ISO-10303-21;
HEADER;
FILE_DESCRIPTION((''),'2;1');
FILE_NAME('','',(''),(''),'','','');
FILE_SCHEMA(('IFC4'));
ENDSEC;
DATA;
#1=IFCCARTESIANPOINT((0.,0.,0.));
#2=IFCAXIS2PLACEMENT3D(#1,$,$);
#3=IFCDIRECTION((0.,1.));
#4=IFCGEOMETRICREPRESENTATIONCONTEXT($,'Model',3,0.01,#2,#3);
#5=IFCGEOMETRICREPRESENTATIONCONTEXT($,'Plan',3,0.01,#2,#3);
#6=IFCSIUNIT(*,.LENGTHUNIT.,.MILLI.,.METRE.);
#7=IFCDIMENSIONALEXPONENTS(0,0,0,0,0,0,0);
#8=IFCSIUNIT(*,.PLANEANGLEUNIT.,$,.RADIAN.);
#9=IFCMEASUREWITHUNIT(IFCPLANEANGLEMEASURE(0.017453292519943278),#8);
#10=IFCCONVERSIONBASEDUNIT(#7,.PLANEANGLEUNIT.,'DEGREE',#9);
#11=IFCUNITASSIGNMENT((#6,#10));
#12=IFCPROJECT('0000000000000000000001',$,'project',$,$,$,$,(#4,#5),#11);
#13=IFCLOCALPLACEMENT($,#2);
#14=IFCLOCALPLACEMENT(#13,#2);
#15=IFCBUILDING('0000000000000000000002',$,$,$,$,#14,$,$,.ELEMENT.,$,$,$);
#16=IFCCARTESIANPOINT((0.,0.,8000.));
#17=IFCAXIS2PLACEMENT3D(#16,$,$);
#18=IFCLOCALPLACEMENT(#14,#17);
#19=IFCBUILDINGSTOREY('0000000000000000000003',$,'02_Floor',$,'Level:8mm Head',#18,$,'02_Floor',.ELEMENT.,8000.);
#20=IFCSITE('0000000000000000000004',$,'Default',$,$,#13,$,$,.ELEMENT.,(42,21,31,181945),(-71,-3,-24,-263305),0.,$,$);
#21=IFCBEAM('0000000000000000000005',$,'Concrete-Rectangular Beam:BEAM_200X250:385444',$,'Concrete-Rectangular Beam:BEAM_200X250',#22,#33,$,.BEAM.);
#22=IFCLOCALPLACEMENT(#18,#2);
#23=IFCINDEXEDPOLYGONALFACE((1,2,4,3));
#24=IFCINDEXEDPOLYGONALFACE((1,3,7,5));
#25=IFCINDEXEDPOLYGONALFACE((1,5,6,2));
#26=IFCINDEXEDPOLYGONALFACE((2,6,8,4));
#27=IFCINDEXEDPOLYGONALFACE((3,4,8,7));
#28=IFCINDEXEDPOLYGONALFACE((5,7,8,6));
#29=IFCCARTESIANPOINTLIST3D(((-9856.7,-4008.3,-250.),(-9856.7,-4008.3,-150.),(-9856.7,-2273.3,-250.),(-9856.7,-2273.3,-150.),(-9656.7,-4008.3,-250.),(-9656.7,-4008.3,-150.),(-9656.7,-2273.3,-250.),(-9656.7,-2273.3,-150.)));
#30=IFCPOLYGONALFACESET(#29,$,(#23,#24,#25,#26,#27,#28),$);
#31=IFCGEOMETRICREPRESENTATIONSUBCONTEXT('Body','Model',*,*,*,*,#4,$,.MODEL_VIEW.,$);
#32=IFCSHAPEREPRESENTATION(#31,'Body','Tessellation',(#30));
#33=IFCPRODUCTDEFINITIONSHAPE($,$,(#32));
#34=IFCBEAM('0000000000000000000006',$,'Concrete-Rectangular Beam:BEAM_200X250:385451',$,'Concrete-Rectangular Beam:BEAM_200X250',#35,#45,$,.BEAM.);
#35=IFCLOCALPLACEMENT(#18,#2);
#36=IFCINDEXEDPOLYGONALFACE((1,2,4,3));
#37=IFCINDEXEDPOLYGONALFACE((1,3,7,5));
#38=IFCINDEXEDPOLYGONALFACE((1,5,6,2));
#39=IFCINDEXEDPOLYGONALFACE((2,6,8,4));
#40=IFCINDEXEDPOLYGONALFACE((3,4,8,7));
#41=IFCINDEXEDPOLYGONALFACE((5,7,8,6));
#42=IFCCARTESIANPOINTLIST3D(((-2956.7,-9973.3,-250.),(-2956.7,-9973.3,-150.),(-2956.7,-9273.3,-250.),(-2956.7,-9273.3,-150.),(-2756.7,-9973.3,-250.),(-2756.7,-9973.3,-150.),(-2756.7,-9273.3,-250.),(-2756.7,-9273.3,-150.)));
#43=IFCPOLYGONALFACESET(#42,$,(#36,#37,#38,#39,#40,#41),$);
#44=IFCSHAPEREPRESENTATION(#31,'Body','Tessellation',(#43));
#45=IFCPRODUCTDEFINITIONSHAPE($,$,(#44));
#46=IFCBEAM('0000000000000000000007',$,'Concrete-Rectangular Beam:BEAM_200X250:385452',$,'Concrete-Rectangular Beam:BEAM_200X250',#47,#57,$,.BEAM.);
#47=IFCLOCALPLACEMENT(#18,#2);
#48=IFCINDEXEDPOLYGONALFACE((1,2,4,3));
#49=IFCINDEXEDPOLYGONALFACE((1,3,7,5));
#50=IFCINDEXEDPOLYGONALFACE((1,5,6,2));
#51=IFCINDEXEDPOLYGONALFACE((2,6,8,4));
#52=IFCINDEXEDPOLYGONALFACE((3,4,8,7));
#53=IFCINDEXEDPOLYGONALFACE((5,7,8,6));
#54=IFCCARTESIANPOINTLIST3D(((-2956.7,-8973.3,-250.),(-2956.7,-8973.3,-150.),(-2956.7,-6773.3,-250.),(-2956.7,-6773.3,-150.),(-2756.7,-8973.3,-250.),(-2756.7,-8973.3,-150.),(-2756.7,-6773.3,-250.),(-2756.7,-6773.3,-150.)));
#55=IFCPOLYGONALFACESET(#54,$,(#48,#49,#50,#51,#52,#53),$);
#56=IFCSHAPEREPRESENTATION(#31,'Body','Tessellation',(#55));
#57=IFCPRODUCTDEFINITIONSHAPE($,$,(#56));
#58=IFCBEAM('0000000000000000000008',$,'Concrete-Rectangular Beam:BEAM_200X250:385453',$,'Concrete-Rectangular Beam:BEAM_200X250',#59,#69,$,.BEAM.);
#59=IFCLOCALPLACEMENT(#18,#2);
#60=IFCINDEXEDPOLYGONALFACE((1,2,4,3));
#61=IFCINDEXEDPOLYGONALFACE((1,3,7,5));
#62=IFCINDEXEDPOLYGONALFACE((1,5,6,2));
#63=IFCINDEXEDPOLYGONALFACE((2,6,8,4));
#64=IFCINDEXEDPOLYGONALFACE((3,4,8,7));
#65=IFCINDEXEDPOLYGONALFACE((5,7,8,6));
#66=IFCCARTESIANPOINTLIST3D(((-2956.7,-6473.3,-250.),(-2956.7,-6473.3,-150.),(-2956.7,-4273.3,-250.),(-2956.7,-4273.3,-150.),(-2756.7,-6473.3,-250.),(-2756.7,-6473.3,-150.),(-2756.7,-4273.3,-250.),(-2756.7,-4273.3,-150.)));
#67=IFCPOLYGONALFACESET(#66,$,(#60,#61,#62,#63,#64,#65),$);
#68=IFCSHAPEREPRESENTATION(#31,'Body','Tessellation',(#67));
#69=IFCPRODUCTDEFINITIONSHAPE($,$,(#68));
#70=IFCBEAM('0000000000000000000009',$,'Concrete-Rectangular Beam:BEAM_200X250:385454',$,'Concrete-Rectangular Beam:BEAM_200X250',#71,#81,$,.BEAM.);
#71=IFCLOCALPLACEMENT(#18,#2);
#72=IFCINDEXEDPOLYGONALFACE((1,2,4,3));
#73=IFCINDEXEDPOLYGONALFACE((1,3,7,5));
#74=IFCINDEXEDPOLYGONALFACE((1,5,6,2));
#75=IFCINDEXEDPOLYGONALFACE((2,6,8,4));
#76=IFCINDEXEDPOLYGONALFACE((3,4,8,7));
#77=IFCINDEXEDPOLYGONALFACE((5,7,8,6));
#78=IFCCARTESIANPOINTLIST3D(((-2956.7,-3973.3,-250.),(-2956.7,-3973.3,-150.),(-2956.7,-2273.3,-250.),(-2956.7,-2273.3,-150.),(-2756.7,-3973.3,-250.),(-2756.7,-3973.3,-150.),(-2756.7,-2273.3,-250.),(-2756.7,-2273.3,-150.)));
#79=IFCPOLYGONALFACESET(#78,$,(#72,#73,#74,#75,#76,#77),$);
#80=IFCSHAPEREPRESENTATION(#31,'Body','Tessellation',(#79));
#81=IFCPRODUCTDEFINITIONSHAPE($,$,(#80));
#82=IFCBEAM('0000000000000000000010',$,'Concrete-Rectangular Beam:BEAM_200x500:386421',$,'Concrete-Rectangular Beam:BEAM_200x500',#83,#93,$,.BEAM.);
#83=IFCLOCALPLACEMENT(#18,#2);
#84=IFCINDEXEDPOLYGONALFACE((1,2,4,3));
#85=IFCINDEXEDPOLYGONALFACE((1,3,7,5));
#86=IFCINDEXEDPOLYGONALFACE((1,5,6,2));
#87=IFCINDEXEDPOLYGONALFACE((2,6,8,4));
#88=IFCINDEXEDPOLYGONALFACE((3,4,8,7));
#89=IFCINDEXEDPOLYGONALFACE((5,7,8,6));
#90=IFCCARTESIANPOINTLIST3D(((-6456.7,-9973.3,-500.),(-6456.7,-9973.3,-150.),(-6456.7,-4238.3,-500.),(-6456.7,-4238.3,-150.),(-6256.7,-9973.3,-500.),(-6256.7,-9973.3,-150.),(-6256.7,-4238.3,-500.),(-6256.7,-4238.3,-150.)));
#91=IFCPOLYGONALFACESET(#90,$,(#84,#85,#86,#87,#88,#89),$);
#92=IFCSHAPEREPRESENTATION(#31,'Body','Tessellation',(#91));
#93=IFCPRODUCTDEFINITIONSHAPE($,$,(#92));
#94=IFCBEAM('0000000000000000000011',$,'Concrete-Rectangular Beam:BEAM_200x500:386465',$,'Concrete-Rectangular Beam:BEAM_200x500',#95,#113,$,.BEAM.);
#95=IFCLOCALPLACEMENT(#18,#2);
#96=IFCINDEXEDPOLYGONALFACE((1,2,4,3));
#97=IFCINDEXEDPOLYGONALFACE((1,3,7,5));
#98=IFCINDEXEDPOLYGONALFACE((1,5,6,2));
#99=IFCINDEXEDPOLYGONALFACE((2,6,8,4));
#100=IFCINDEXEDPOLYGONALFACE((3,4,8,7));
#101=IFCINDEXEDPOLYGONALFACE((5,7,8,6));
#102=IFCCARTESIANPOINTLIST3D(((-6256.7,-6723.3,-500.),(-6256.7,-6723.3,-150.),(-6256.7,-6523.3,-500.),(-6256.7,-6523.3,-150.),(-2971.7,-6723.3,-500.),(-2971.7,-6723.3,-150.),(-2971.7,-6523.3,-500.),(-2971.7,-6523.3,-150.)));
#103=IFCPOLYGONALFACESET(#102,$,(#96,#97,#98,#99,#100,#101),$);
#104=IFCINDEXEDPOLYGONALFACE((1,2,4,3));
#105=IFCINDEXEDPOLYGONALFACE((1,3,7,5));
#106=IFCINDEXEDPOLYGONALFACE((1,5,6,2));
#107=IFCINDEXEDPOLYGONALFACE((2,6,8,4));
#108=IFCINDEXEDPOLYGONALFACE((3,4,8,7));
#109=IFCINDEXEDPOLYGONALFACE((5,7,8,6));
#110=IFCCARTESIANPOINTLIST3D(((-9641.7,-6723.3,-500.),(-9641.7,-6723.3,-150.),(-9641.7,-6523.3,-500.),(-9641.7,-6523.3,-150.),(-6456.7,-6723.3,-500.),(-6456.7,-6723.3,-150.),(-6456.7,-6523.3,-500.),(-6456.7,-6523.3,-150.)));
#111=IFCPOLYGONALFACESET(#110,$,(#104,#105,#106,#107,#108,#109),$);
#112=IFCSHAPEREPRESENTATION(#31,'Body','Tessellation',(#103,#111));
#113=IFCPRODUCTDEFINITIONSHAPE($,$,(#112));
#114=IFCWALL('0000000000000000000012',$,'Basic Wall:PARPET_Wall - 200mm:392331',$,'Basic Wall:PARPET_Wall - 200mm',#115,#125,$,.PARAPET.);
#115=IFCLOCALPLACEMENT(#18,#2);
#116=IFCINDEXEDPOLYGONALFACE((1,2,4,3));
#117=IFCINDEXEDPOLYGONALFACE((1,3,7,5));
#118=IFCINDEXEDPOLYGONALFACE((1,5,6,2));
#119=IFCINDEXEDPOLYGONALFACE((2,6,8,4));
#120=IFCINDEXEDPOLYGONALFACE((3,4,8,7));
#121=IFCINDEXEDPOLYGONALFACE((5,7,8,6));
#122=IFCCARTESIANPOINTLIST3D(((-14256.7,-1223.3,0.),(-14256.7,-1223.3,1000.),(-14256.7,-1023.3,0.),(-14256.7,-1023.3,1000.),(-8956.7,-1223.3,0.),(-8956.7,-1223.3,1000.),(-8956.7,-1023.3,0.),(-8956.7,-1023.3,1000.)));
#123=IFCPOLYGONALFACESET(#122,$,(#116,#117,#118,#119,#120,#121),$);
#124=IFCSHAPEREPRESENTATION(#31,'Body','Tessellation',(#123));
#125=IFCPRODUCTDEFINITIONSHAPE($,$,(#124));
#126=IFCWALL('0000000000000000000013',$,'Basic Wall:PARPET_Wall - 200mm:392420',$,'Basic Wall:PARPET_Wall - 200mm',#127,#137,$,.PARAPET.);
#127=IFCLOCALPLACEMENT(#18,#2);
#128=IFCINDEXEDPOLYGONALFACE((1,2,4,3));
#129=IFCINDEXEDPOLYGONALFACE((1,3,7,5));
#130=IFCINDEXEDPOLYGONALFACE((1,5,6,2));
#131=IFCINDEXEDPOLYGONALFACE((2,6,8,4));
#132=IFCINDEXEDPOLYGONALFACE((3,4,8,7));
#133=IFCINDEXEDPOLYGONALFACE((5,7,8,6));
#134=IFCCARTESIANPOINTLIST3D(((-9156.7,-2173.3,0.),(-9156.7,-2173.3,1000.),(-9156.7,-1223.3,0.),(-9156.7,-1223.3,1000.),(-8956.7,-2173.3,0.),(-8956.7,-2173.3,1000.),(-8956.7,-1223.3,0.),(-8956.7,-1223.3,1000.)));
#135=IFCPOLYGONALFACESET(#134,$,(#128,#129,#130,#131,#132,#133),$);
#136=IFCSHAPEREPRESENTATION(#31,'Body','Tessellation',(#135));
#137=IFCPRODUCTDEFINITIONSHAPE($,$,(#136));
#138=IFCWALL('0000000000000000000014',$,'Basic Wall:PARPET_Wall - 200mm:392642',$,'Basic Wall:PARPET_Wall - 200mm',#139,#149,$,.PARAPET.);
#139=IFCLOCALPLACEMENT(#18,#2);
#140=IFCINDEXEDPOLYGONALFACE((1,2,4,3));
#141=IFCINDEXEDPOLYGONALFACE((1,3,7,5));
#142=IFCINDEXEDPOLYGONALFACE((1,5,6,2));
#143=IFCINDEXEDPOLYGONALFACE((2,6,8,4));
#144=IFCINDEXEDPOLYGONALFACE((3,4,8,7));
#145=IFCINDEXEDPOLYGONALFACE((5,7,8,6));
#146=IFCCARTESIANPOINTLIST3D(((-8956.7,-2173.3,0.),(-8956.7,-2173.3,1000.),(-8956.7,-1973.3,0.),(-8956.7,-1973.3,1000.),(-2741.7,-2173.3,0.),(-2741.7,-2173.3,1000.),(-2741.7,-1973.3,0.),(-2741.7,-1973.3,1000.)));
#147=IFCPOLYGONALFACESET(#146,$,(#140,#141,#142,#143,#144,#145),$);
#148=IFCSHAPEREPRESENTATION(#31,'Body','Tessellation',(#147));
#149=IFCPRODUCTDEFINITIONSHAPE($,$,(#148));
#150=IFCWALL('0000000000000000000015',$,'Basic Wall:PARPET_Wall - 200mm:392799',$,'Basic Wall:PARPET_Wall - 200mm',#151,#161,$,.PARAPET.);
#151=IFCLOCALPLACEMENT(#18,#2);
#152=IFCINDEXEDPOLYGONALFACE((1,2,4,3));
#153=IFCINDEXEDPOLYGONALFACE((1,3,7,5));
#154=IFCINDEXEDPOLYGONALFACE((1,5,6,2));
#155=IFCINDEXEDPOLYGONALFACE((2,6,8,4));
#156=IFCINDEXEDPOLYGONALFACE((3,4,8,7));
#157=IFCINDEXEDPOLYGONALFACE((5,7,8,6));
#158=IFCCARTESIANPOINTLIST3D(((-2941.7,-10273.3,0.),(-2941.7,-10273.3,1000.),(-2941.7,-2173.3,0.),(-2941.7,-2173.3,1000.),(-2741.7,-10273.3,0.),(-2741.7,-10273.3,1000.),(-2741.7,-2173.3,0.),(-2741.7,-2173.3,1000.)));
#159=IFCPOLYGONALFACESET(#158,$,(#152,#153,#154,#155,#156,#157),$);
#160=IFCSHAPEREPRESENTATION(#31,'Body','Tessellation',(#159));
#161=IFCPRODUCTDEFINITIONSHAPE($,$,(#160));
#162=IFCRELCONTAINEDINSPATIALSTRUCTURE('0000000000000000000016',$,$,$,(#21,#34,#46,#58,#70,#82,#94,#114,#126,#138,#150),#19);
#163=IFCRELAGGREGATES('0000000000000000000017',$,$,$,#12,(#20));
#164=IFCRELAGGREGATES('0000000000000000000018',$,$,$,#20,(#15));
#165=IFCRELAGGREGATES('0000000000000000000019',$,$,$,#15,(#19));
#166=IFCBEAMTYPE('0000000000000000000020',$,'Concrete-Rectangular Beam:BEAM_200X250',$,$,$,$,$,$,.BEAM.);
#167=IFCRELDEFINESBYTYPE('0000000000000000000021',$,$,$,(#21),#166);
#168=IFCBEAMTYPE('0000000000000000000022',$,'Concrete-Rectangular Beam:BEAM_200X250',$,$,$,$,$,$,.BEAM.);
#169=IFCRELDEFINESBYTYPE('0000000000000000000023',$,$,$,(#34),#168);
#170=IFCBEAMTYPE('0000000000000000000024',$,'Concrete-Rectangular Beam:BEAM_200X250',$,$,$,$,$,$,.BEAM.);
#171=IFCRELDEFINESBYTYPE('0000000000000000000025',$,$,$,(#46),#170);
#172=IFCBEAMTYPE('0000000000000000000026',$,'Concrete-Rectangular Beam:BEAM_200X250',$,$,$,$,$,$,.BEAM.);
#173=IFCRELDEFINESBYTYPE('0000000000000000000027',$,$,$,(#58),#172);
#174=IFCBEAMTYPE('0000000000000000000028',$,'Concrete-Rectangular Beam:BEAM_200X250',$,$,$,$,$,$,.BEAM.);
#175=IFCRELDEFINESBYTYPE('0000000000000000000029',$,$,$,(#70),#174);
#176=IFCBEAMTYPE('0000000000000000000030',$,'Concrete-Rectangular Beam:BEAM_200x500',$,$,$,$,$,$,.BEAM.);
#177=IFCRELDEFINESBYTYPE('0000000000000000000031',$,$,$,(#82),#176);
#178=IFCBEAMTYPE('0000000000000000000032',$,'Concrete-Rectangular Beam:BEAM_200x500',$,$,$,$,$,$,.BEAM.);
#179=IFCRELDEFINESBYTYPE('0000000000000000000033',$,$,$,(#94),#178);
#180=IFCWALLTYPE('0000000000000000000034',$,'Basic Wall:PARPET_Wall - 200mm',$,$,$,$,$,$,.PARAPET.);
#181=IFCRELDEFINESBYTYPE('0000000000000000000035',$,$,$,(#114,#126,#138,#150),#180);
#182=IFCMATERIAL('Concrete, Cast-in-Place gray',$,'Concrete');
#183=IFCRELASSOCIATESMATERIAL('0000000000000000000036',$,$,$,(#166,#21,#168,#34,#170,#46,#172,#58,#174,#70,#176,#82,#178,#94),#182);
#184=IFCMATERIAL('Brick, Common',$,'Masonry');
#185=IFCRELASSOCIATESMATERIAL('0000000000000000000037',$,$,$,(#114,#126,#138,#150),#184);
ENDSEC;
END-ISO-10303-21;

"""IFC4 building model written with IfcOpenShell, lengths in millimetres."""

from ifc_helpers import new_model, entity, si_unit, converted_unit, direction, frame, origin, place, context, subcontext, project, spatial, indexed_curve, outline, extrude, source, transform, mapped, material, type_object, type_shapes, element, save


model = new_model("IFC4")

# Units and contexts
model_context = context("Model", 3, precision=0.01, world=origin(), true_north=direction((0.0, 1.0)))
plan_context = context("Plan", 3, precision=0.01, world=origin(), true_north=direction((0.0, 1.0)))
body_context = subcontext(model_context, "Body", "Model", "MODEL_VIEW")
ifc_project = project(units=[si_unit("LENGTHUNIT", "METRE", prefix="MILLI"), converted_unit("PLANEANGLEUNIT", "DEGREE", entity("IfcPlaneAngleMeasure", 0.017453292519943278), si_unit("PLANEANGLEUNIT", "RADIAN"), dimensions=[0, 0, 0, 0, 0, 0, 0])], contexts=[model_context, plan_context])

# Site, building, storey
site_placement = place(None, origin())
site = spatial("IfcSite", under=ifc_project, at=site_placement, Name="Default", CompositionType="ELEMENT", RefLatitude=(42, 21, 31, 181945), RefLongitude=(-71, -3, -24, -263305), RefElevation=0.0)
building_placement = place(site_placement, origin())
building = spatial("IfcBuilding", under=site, at=building_placement, CompositionType="ELEMENT")
storey_placement = place(building_placement, frame((0.0, 0.0, 8000.0)))
storey = spatial("IfcBuildingStorey", under=building, at=storey_placement, Name="02_Floor", ObjectType="Level:8mm Head", LongName="02_Floor", CompositionType="ELEMENT", Elevation=8000.0)

# Beams
ifc_material_1 = material(Name="Concrete, Cast-in-Place gray", Category="Concrete")
beam_type_1 = type_object("IfcBeamType", Name="Concrete-Rectangular Beam:BEAM_200X250", PredefinedType="BEAM", material=ifc_material_1)
shared_shape_1 = source(origin(), body_context, "Body", "SweptSolid", [
    extrude(outline(indexed_curve([(-100.0, -50.0), (100.0, -50.0), (100.0, 50.0), (-100.0, 50.0), (-100.0, -50.0)], self_intersect=False)), frame((-9756.7, -4008.3, 7800.0), z_axis=(0.0, 1.0, 0.0), x_axis=(-1.0, 0.0, 0.0)), (0.0, 0.0, 1.0), 1735.0),
])
type_shapes(beam_type_1, [shared_shape_1])
beam_1_placement = place(storey_placement, frame((0.0, 0.0, -8000.0)))
element("IfcBeam", 1, at=beam_1_placement, inside=storey, type_object=beam_type_1, material=ifc_material_1, Name="Concrete-Rectangular Beam:BEAM_200X250:385444", ObjectType="Concrete-Rectangular Beam:BEAM_200X250", PredefinedType="BEAM", context=body_context, shape_type="MappedRepresentation", body=[
    mapped(shared_shape_1, transform((0.0, 0.0, 0.0), scale=1.0)),
])
beam_type_2 = type_object("IfcBeamType", Name="Concrete-Rectangular Beam:BEAM_200X250", PredefinedType="BEAM", material=ifc_material_1)
shared_shape_2 = source(origin(), body_context, "Body", "SweptSolid", [
    extrude(outline(indexed_curve([(-100.0, -50.0), (100.0, -50.0), (100.0, 50.0), (-100.0, 50.0), (-100.0, -50.0)], self_intersect=False)), frame((-2856.7, -9973.3, 7800.0), z_axis=(0.0, 1.0, 0.0), x_axis=(-1.0, 0.0, 0.0)), (0.0, 0.0, 1.0), 700.0),
])
type_shapes(beam_type_2, [shared_shape_2])
beam_2_placement = place(storey_placement, frame((0.0, 0.0, -8000.0)))
element("IfcBeam", 2, at=beam_2_placement, inside=storey, type_object=beam_type_2, material=ifc_material_1, Name="Concrete-Rectangular Beam:BEAM_200X250:385451", ObjectType="Concrete-Rectangular Beam:BEAM_200X250", PredefinedType="BEAM", context=body_context, shape_type="MappedRepresentation", body=[
    mapped(shared_shape_2, transform((0.0, 0.0, 0.0), scale=1.0)),
])
beam_type_3 = type_object("IfcBeamType", Name="Concrete-Rectangular Beam:BEAM_200X250", PredefinedType="BEAM", material=ifc_material_1)
shared_shape_3 = source(origin(), body_context, "Body", "SweptSolid", [
    extrude(outline(indexed_curve([(-100.0, -50.0), (100.0, -50.0), (100.0, 50.0), (-100.0, 50.0), (-100.0, -50.0)], self_intersect=False)), frame((-2856.7, -8973.3, 7800.0), z_axis=(0.0, 1.0, 0.0), x_axis=(-1.0, 0.0, 0.0)), (0.0, 0.0, 1.0), 2200.0),
])
type_shapes(beam_type_3, [shared_shape_3])
beam_3_placement = place(storey_placement, frame((0.0, 0.0, -8000.0)))
element("IfcBeam", 3, at=beam_3_placement, inside=storey, type_object=beam_type_3, material=ifc_material_1, Name="Concrete-Rectangular Beam:BEAM_200X250:385452", ObjectType="Concrete-Rectangular Beam:BEAM_200X250", PredefinedType="BEAM", context=body_context, shape_type="MappedRepresentation", body=[
    mapped(shared_shape_3, transform((0.0, 0.0, 0.0), scale=1.0)),
])
beam_type_4 = type_object("IfcBeamType", Name="Concrete-Rectangular Beam:BEAM_200X250", PredefinedType="BEAM", material=ifc_material_1)
shared_shape_4 = source(origin(), body_context, "Body", "SweptSolid", [
    extrude(outline(indexed_curve([(-100.0, -50.0), (100.0, -50.0), (100.0, 50.0), (-100.0, 50.0), (-100.0, -50.0)], self_intersect=False)), frame((-2856.7, -6473.3, 7800.0), z_axis=(0.0, 1.0, 0.0), x_axis=(-1.0, 0.0, 0.0)), (0.0, 0.0, 1.0), 2200.0),
])
type_shapes(beam_type_4, [shared_shape_4])
beam_4_placement = place(storey_placement, frame((0.0, 0.0, -8000.0)))
element("IfcBeam", 4, at=beam_4_placement, inside=storey, type_object=beam_type_4, material=ifc_material_1, Name="Concrete-Rectangular Beam:BEAM_200X250:385453", ObjectType="Concrete-Rectangular Beam:BEAM_200X250", PredefinedType="BEAM", context=body_context, shape_type="MappedRepresentation", body=[
    mapped(shared_shape_4, transform((0.0, 0.0, 0.0), scale=1.0)),
])
beam_type_5 = type_object("IfcBeamType", Name="Concrete-Rectangular Beam:BEAM_200X250", PredefinedType="BEAM", material=ifc_material_1)
shared_shape_5 = source(origin(), body_context, "Body", "SweptSolid", [
    extrude(outline(indexed_curve([(-100.0, -50.0), (100.0, -50.0), (100.0, 50.0), (-100.0, 50.0), (-100.0, -50.0)], self_intersect=False)), frame((-2856.7, -3973.3, 7800.0), z_axis=(0.0, 1.0, 0.0), x_axis=(-1.0, 0.0, 0.0)), (0.0, 0.0, 1.0), 1700.0),
])
type_shapes(beam_type_5, [shared_shape_5])
beam_5_placement = place(storey_placement, frame((0.0, 0.0, -8000.0)))
element("IfcBeam", 5, at=beam_5_placement, inside=storey, type_object=beam_type_5, material=ifc_material_1, Name="Concrete-Rectangular Beam:BEAM_200X250:385454", ObjectType="Concrete-Rectangular Beam:BEAM_200X250", PredefinedType="BEAM", context=body_context, shape_type="MappedRepresentation", body=[
    mapped(shared_shape_5, transform((0.0, 0.0, 0.0), scale=1.0)),
])
beam_type_6 = type_object("IfcBeamType", Name="Concrete-Rectangular Beam:BEAM_200x500", PredefinedType="BEAM", material=ifc_material_1)
shared_shape_6 = source(origin(), body_context, "Body", "SweptSolid", [
    extrude(outline(indexed_curve([(-100.0, -175.0), (100.0, -175.0), (100.0, 175.0), (-100.0, 175.0), (-100.0, -175.0)], self_intersect=False)), frame((-6356.7, -4238.3, 7675.0), z_axis=(0.0, -1.0, 0.0), x_axis=(-1.0, 0.0, 0.0)), (0.0, 0.0, 1.0), 5735.0),
])
type_shapes(beam_type_6, [shared_shape_6])
beam_6_placement = place(storey_placement, frame((0.0, 0.0, -8000.0)))
element("IfcBeam", 6, at=beam_6_placement, inside=storey, type_object=beam_type_6, material=ifc_material_1, Name="Concrete-Rectangular Beam:BEAM_200x500:386421", ObjectType="Concrete-Rectangular Beam:BEAM_200x500", PredefinedType="BEAM", context=body_context, shape_type="MappedRepresentation", body=[
    mapped(shared_shape_6, transform((0.0, 0.0, 0.0), scale=1.0)),
])
beam_type_7 = type_object("IfcBeamType", Name="Concrete-Rectangular Beam:BEAM_200x500", PredefinedType="BEAM", material=ifc_material_1)
shared_shape_7 = source(origin(), body_context, "Body", "SweptSolid", [
    extrude(outline(indexed_curve([(-175.0, -100.0), (175.0, -100.0), (175.0, 100.0), (-175.0, 100.0), (-175.0, -100.0)], self_intersect=False)), frame((-6256.7, -6623.3, 7675.0), z_axis=(1.0, 0.0, 0.0), x_axis=(0.0, 0.0, -1.0)), (0.0, 0.0, 1.0), 3285.0),
    extrude(outline(indexed_curve([(-175.0, -100.0), (175.0, -100.0), (175.0, 100.0), (-175.0, 100.0), (-175.0, -100.0)], self_intersect=False)), frame((-9641.7, -6623.3, 7675.0), z_axis=(1.0, 0.0, 0.0), x_axis=(0.0, 0.0, -1.0)), (0.0, 0.0, 1.0), 3185.0),
])
type_shapes(beam_type_7, [shared_shape_7])
beam_7_placement = place(storey_placement, frame((0.0, 0.0, -8000.0)))
element("IfcBeam", 7, at=beam_7_placement, inside=storey, type_object=beam_type_7, material=ifc_material_1, Name="Concrete-Rectangular Beam:BEAM_200x500:386465", ObjectType="Concrete-Rectangular Beam:BEAM_200x500", PredefinedType="BEAM", context=body_context, shape_type="MappedRepresentation", body=[
    mapped(shared_shape_7, transform((0.0, 0.0, 0.0), scale=1.0)),
])

# Walls
ifc_material_2 = material(Name="Brick, Common", Category="Masonry")
wall_type = type_object("IfcWallType", Name="Basic Wall:PARPET_Wall - 200mm", PredefinedType="PARAPET")
wall_1_placement = place(storey_placement, frame((-14256.7, -1123.3, 0.0)))
element("IfcWall", 8, at=wall_1_placement, inside=storey, type_object=wall_type, material=ifc_material_2, Name="Basic Wall:PARPET_Wall - 200mm:392331", ObjectType="Basic Wall:PARPET_Wall - 200mm", PredefinedType="PARAPET", context=body_context, shape_type="SweptSolid", body=[
    extrude(outline(indexed_curve([(5300.0, 100.0), (0.0, 100.0), (0.0, -100.0), (5300.0, -100.0), (5300.0, 100.0)], self_intersect=False)), origin(), (0.0, 0.0, 1.0), 1000.0),
])
wall_2_placement = place(storey_placement, frame((-9056.7, -1223.3, 0.0), z_axis=(0.0, 0.0, 1.0), x_axis=(0.0, -1.0, 0.0)))
element("IfcWall", 9, at=wall_2_placement, inside=storey, type_object=wall_type, material=ifc_material_2, Name="Basic Wall:PARPET_Wall - 200mm:392420", ObjectType="Basic Wall:PARPET_Wall - 200mm", PredefinedType="PARAPET", context=body_context, shape_type="SweptSolid", body=[
    extrude(outline(indexed_curve([(950.0, 100.0), (0.0, 100.0), (0.0, -100.0), (950.0, -100.0), (950.0, 100.0)], self_intersect=False)), origin(), (0.0, 0.0, 1.0), 1000.0),
])
wall_3_placement = place(storey_placement, frame((-8956.7, -2073.3, 0.0)))
element("IfcWall", 10, at=wall_3_placement, inside=storey, type_object=wall_type, material=ifc_material_2, Name="Basic Wall:PARPET_Wall - 200mm:392642", ObjectType="Basic Wall:PARPET_Wall - 200mm", PredefinedType="PARAPET", context=body_context, shape_type="SweptSolid", body=[
    extrude(outline(indexed_curve([(6215.0, 100.0), (0.0, 100.0), (0.0, -100.0), (6215.0, -100.0), (6215.0, 100.0)], self_intersect=False)), origin(), (0.0, 0.0, 1.0), 1000.0),
])
wall_4_placement = place(storey_placement, frame((-2841.7, -2173.3, 0.0), z_axis=(0.0, 0.0, 1.0), x_axis=(0.0, -1.0, 0.0)))
element("IfcWall", 11, at=wall_4_placement, inside=storey, type_object=wall_type, material=ifc_material_2, Name="Basic Wall:PARPET_Wall - 200mm:392799", ObjectType="Basic Wall:PARPET_Wall - 200mm", PredefinedType="PARAPET", context=body_context, shape_type="SweptSolid", body=[
    extrude(outline(indexed_curve([(8100.0, 100.0), (0.0, 100.0), (0.0, -100.0), (8100.0, -100.0), (8100.0, 100.0)], self_intersect=False)), origin(), (0.0, 0.0, 1.0), 1000.0),
])

save(model, "model.ifc")
